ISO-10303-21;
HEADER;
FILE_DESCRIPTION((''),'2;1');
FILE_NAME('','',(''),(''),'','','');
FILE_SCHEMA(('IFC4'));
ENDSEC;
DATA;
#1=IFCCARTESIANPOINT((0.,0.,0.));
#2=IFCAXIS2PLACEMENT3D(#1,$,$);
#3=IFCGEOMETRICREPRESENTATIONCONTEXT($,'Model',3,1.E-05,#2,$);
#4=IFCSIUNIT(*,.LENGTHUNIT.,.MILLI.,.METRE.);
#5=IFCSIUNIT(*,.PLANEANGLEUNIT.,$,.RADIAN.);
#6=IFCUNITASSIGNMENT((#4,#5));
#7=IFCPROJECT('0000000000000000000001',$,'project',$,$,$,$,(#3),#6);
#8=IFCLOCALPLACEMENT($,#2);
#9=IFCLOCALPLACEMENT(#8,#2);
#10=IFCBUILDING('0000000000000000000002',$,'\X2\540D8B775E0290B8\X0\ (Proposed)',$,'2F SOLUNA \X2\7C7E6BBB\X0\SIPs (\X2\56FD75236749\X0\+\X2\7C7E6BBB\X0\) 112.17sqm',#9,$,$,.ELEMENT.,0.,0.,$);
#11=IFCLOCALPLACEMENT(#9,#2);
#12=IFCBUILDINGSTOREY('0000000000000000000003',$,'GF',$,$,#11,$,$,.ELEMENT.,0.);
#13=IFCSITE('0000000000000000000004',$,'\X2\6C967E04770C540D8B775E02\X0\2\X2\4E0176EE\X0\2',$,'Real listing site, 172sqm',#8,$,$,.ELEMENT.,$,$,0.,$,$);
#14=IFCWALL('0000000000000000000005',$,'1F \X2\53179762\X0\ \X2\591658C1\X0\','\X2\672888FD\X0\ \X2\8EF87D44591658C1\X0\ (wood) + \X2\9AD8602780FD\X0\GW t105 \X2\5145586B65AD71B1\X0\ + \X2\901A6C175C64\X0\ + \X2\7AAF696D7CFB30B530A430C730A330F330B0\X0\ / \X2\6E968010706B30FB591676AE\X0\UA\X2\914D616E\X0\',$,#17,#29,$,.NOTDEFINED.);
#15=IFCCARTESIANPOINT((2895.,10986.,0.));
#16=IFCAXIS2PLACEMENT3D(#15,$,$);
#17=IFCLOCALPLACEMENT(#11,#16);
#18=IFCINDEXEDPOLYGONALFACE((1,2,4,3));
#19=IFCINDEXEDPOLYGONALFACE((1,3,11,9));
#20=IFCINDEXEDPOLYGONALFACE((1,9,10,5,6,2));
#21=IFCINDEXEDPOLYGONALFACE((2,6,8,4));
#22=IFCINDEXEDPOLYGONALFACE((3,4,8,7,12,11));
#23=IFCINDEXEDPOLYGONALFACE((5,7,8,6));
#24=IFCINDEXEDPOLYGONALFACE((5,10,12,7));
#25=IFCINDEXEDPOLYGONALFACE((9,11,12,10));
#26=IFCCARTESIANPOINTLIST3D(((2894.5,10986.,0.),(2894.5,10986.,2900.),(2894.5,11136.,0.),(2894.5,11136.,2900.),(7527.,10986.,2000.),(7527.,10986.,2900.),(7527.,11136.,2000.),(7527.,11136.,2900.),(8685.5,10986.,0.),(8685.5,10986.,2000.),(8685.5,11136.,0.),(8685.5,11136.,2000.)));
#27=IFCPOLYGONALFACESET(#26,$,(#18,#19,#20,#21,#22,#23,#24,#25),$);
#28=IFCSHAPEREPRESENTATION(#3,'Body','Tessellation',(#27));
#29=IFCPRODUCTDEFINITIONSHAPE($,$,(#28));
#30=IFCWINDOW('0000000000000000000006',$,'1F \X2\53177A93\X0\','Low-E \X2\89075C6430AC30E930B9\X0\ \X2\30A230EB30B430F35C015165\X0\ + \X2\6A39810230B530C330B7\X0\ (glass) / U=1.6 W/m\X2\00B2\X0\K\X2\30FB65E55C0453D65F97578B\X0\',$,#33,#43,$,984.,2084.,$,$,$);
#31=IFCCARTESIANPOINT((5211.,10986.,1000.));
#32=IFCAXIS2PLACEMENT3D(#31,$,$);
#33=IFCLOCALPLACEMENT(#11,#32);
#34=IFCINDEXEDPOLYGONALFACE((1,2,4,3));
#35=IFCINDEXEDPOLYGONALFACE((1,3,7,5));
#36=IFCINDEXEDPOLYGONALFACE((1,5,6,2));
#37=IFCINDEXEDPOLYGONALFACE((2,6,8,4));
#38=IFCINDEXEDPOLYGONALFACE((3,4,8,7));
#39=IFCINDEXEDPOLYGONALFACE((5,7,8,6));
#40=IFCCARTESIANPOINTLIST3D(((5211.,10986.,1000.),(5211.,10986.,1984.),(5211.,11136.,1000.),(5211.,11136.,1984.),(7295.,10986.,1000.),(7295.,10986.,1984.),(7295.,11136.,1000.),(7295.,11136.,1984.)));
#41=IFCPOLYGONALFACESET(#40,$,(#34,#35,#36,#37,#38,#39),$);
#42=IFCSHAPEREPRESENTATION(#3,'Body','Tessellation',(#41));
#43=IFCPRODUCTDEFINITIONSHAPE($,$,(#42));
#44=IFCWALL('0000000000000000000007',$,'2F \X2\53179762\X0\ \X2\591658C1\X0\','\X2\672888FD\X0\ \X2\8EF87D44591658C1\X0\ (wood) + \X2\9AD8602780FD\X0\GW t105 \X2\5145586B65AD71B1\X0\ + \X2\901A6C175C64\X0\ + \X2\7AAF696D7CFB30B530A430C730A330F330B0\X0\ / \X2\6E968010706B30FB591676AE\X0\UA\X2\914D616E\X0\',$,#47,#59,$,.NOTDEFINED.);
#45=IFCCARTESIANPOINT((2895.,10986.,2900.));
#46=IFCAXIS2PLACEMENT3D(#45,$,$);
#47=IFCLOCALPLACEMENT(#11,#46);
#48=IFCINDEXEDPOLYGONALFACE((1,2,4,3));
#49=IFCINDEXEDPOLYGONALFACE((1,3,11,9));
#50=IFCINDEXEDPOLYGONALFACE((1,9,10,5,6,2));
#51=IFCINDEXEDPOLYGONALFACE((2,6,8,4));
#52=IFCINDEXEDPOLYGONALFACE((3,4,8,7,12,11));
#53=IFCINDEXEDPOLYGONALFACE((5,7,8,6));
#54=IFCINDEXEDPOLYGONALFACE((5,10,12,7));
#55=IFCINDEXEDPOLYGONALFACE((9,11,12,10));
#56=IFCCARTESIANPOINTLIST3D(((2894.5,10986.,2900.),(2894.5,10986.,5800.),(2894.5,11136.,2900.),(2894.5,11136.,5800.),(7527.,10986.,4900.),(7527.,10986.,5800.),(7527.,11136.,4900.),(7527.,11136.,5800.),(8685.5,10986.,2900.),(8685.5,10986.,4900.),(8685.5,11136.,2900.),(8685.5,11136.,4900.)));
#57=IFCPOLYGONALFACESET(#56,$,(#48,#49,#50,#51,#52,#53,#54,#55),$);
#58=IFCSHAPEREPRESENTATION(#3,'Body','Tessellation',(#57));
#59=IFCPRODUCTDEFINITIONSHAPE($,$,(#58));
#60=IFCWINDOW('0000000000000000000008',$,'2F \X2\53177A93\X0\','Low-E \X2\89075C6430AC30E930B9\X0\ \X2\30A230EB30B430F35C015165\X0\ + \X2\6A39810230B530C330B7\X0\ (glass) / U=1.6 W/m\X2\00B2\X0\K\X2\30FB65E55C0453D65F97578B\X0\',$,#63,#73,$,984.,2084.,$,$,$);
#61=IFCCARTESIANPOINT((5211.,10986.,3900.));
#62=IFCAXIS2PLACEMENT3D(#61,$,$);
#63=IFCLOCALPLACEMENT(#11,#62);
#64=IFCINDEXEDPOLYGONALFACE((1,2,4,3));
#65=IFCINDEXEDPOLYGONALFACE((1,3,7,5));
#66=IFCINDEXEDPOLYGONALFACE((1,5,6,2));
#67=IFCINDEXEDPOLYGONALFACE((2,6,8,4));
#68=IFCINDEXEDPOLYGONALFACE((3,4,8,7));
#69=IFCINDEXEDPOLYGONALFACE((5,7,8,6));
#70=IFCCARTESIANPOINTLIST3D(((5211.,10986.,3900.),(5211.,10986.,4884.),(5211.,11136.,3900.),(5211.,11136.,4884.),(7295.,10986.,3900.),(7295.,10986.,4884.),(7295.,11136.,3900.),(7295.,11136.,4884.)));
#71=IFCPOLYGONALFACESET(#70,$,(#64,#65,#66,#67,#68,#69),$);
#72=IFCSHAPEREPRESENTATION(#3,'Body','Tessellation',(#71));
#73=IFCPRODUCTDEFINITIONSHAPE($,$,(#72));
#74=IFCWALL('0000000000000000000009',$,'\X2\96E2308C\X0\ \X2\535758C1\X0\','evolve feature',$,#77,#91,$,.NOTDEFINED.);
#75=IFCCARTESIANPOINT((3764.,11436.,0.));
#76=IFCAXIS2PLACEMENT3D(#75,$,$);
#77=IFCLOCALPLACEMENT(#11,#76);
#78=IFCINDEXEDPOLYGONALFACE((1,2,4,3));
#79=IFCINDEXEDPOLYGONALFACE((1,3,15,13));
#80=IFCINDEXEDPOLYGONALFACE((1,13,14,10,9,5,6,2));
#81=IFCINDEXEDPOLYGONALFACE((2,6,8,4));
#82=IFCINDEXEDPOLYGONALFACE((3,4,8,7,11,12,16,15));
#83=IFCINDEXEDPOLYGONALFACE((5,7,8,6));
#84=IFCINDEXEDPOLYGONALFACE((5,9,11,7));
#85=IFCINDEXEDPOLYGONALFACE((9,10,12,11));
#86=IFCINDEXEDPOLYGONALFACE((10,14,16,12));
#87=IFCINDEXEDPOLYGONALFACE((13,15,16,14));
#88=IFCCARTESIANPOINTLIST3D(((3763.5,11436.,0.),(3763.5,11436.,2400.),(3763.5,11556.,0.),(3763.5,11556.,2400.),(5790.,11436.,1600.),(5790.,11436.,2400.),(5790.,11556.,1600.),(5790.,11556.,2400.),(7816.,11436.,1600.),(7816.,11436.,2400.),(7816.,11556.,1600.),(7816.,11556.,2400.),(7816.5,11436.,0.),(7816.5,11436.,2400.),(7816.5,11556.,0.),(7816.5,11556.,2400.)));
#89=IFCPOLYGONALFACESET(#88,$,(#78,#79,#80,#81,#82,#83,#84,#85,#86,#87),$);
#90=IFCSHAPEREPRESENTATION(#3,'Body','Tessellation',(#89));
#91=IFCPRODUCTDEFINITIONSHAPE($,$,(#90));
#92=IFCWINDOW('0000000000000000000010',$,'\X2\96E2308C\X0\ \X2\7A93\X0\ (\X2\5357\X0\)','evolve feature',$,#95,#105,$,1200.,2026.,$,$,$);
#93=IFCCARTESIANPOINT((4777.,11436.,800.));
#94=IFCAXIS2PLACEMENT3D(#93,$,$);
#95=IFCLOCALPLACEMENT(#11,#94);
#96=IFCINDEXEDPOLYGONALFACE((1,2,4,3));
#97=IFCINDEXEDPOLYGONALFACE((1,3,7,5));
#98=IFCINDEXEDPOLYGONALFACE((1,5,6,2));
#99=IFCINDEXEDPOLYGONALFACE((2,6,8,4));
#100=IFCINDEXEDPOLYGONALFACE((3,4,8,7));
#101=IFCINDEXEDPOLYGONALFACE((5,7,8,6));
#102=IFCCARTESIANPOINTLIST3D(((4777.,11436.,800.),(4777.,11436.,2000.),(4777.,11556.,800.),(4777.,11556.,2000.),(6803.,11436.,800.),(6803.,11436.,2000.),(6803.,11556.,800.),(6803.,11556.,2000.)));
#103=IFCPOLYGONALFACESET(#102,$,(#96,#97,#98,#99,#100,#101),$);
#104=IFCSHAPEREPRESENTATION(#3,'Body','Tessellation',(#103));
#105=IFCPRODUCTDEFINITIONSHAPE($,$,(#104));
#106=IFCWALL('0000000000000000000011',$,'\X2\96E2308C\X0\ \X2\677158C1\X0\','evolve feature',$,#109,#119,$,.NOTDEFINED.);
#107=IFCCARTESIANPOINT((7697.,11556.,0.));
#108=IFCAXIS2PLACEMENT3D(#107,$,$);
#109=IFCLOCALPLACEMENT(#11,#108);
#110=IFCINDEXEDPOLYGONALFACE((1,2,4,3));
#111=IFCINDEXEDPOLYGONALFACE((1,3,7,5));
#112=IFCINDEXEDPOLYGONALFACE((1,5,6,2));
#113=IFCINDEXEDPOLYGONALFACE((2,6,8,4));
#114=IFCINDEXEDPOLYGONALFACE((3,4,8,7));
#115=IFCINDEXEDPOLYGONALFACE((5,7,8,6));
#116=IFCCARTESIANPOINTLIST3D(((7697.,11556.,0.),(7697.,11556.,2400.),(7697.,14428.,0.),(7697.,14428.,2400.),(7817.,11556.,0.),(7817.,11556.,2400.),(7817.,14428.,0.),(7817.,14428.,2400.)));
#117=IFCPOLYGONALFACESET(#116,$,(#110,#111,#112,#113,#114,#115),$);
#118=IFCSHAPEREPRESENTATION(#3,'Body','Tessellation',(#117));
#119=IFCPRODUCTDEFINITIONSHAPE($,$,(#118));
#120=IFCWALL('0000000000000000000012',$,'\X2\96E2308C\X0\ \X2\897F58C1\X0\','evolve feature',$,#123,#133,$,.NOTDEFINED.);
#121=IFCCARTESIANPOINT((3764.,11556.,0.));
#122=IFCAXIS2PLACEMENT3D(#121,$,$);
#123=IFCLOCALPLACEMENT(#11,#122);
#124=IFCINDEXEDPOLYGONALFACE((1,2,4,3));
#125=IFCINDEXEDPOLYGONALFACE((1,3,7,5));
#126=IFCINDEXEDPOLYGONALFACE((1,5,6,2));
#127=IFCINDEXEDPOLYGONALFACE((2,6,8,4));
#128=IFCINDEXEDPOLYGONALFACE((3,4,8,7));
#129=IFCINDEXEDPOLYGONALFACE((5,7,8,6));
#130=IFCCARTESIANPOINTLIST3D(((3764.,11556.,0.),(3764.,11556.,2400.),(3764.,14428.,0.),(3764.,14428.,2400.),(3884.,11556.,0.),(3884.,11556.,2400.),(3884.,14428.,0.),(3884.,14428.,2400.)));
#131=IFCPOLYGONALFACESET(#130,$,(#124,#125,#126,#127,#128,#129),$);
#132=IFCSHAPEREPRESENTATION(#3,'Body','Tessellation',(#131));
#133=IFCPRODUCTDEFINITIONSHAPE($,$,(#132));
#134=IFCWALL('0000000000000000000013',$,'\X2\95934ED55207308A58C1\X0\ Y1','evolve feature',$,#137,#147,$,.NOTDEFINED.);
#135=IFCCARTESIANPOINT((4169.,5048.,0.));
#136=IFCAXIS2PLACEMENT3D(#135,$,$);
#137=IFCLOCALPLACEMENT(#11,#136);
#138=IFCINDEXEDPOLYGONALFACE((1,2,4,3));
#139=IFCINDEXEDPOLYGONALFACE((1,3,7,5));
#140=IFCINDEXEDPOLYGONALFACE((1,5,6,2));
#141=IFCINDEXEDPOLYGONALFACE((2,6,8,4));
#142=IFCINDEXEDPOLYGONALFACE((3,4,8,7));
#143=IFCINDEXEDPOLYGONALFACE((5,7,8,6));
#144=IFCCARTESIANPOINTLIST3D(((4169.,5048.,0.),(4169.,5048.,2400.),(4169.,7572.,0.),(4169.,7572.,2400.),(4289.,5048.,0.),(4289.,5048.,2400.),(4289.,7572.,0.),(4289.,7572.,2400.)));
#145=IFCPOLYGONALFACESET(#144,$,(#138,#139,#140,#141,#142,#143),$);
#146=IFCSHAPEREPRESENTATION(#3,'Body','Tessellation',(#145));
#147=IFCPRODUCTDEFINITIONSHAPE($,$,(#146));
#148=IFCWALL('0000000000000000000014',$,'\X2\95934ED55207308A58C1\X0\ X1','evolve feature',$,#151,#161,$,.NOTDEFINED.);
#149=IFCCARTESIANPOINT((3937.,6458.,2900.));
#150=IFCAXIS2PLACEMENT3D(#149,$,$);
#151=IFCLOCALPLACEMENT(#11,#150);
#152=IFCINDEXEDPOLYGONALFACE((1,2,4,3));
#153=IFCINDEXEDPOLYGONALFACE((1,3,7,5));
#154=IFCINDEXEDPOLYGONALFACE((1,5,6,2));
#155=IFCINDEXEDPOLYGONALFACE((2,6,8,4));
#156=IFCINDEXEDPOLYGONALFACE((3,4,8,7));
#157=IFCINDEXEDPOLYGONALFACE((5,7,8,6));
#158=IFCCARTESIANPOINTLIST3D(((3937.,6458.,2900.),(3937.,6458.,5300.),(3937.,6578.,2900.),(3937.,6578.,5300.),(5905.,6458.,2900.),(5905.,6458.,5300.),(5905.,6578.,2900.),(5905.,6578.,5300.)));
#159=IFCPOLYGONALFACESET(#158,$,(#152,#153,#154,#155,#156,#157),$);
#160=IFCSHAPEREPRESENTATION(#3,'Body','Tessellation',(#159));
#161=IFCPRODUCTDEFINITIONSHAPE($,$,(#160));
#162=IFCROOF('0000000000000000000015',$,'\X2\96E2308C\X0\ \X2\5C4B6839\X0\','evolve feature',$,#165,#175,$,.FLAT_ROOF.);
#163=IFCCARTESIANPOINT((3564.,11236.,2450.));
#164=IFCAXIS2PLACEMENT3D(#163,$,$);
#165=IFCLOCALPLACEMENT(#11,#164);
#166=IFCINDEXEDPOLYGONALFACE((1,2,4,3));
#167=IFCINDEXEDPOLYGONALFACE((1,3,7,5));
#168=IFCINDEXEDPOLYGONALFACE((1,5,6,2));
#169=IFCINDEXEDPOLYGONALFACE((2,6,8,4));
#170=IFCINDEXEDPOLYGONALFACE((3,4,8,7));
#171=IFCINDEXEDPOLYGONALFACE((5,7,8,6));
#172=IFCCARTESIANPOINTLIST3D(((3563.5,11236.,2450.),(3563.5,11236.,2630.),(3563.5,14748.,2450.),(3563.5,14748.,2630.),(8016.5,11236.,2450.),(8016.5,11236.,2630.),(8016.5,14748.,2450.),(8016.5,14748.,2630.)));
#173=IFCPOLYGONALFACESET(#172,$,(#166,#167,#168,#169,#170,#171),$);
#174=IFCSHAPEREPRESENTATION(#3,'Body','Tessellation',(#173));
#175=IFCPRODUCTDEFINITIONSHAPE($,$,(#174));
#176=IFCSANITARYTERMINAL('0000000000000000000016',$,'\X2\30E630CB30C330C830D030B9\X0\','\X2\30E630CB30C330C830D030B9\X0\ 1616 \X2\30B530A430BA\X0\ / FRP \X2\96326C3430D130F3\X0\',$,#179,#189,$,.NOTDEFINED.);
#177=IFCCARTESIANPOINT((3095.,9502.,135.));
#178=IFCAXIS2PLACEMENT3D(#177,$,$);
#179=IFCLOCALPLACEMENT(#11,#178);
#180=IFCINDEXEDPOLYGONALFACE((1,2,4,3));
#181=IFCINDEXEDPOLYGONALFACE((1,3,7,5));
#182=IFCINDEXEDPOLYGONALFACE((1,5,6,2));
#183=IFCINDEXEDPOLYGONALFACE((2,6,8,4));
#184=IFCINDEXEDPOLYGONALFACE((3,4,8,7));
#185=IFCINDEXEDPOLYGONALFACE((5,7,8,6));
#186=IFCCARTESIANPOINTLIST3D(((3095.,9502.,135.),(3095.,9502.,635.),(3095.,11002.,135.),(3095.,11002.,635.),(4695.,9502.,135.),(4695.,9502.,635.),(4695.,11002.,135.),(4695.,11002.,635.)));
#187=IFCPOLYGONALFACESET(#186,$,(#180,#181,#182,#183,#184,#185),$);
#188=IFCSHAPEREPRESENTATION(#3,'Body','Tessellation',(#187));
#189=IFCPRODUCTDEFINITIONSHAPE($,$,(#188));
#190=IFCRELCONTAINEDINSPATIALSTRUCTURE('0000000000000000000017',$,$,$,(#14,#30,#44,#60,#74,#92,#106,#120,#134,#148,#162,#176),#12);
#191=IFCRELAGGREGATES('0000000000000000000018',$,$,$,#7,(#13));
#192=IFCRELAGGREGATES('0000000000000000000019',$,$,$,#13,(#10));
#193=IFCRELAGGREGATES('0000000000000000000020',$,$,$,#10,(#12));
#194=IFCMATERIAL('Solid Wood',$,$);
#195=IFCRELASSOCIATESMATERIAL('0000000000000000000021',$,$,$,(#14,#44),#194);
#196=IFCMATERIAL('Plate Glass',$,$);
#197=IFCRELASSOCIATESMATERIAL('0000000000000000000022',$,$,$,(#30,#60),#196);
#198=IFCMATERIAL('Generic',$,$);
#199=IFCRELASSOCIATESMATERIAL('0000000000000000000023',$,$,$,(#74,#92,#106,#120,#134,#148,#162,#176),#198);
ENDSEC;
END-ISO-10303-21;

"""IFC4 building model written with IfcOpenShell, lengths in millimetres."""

from ifc_helpers import new_model, si_unit, frame, frame_2d, origin, place, context, project, spatial, rectangle, extrude, material, element, fill, save


model = new_model("IFC4")

# Units and contexts
model_context = context("Model", 3, precision=1e-05, world=origin())
ifc_project = project(units=[si_unit("LENGTHUNIT", "METRE", prefix="MILLI"), si_unit("PLANEANGLEUNIT", "RADIAN")], contexts=[model_context])

# Site, building, storey
site_placement = place(None, origin())
site = spatial("IfcSite", under=ifc_project, at=site_placement, Name="沖縄県名護市2丁目2", ObjectType="Real listing site, 172sqm", CompositionType="ELEMENT", RefElevation=0.0)
building_placement = place(site_placement, origin())
building = spatial("IfcBuilding", under=site, at=building_placement, Name="名護市邸 (Proposed)", ObjectType="2F SOLUNA 籾殻SIPs (国産杉+籾殻) 112.17sqm", CompositionType="ELEMENT", ElevationOfRefHeight=0.0, ElevationOfTerrain=0.0)
storey_placement = place(building_placement, origin())
storey = spatial("IfcBuildingStorey", under=building, at=storey_placement, Name="GF", CompositionType="ELEMENT", Elevation=0.0)

# Shared definitions
ifc_material_1 = material(Name="Generic")

# Wall, opening, window
ifc_material_2 = material(Name="Solid Wood")
wall_1_placement = place(storey_placement, frame((2895.0, 10986.0, 0.0)))
wall_1 = element("IfcWall", 1, at=wall_1_placement, inside=storey, material=ifc_material_2, Name="1F 北面 外壁", Description="木製 軸組外壁 (wood) + 高性能GW t105 充填断熱 + 通気層 + 窯業系サイディング / 準耐火・外皮UA配慮", PredefinedType="NOTDEFINED", context=model_context, shape_type="SweptSolid", body=[
    extrude(rectangle(XDim=5791.0, YDim=150.0, at=frame_2d((2895.0, 75.0))), frame((2895.0, 10986.0, 0.0)), (0.0, 0.0, 1.0), 2900.0),
])
opening_1_placement = place(storey_placement, frame((5211.0, 10986.0, 1000.0)))
opening_1 = element("IfcOpeningElement", 2, at=opening_1_placement, cuts=wall_1, PredefinedType="NOTDEFINED", context=model_context, shape_type="SweptSolid", body=[
    extrude(rectangle(XDim=2084.0, YDim=150.0, at=frame_2d((1042.0, 75.0))), frame((5211.0, 10986.0, 1000.0)), (0.0, 0.0, 1.0), 984.0),
])
ifc_material_3 = material(Name="Plate Glass")
window_1_placement = place(storey_placement, frame((5211.0, 10986.0, 1000.0)))
window_1 = element("IfcWindow", 3, at=window_1_placement, inside=storey, material=ifc_material_3, Name="1F 北窓", Description="Low-E 複層ガラス アルゴン封入 + 樹脂サッシ (glass) / U=1.6 W/m²K・日射取得型", OverallHeight=984.0, OverallWidth=2084.0, context=model_context, shape_type="SweptSolid", body=[
    extrude(rectangle(XDim=2084.0, YDim=150.0, at=frame_2d((1042.0, 75.0))), frame((5211.0, 10986.0, 1000.0)), (0.0, 0.0, 1.0), 984.0),
])
fill(opening_1, window_1)

# Wall, opening, window
wall_2_placement = place(storey_placement, frame((2895.0, 10986.0, 2900.0)))
wall_2 = element("IfcWall", 4, at=wall_2_placement, inside=storey, material=ifc_material_2, Name="2F 北面 外壁", Description="木製 軸組外壁 (wood) + 高性能GW t105 充填断熱 + 通気層 + 窯業系サイディング / 準耐火・外皮UA配慮", PredefinedType="NOTDEFINED", context=model_context, shape_type="SweptSolid", body=[
    extrude(rectangle(XDim=5791.0, YDim=150.0, at=frame_2d((2895.0, 75.0))), frame((2895.0, 10986.0, 2900.0)), (0.0, 0.0, 1.0), 2900.0),
])
opening_2_placement = place(storey_placement, frame((5211.0, 10986.0, 3900.0)))
opening_2 = element("IfcOpeningElement", 5, at=opening_2_placement, cuts=wall_2, PredefinedType="NOTDEFINED", context=model_context, shape_type="SweptSolid", body=[
    extrude(rectangle(XDim=2084.0, YDim=150.0, at=frame_2d((1042.0, 75.0))), frame((5211.0, 10986.0, 3900.0)), (0.0, 0.0, 1.0), 984.0),
])
window_2_placement = place(storey_placement, frame((5211.0, 10986.0, 3900.0)))
window_2 = element("IfcWindow", 6, at=window_2_placement, inside=storey, material=ifc_material_3, Name="2F 北窓", Description="Low-E 複層ガラス アルゴン封入 + 樹脂サッシ (glass) / U=1.6 W/m²K・日射取得型", OverallHeight=984.0, OverallWidth=2084.0, context=model_context, shape_type="SweptSolid", body=[
    extrude(rectangle(XDim=2084.0, YDim=150.0, at=frame_2d((1042.0, 75.0))), frame((5211.0, 10986.0, 3900.0)), (0.0, 0.0, 1.0), 984.0),
])
fill(opening_2, window_2)

# Wall, opening, window
wall_3_placement = place(storey_placement, frame((3764.0, 11436.0, 0.0)))
wall_3 = element("IfcWall", 7, at=wall_3_placement, inside=storey, material=ifc_material_1, Name="離れ 南壁", Description="evolve feature", PredefinedType="NOTDEFINED", context=model_context, shape_type="SweptSolid", body=[
    extrude(rectangle(XDim=4053.0, YDim=120.0, at=frame_2d((2026.0, 60.0))), frame((3764.0, 11436.0, 0.0)), (0.0, 0.0, 1.0), 2400.0),
])
opening_3_placement = place(storey_placement, frame((4777.0, 11436.0, 800.0)))
opening_3 = element("IfcOpeningElement", 8, at=opening_3_placement, cuts=wall_3, PredefinedType="NOTDEFINED", context=model_context, shape_type="SweptSolid", body=[
    extrude(rectangle(XDim=2026.0, YDim=120.0, at=frame_2d((1013.0, 60.0))), frame((4777.0, 11436.0, 800.0)), (0.0, 0.0, 1.0), 1200.0),
])
window_3_placement = place(storey_placement, frame((4777.0, 11436.0, 800.0)))
window_3 = element("IfcWindow", 9, at=window_3_placement, inside=storey, material=ifc_material_1, Name="離れ 窓 (南)", Description="evolve feature", OverallHeight=1200.0, OverallWidth=2026.0, context=model_context, shape_type="SweptSolid", body=[
    extrude(rectangle(XDim=2026.0, YDim=120.0, at=frame_2d((1013.0, 60.0))), frame((4777.0, 11436.0, 800.0)), (0.0, 0.0, 1.0), 1200.0),
])
fill(opening_3, window_3)

# Walls
wall_4_placement = place(storey_placement, frame((7697.0, 11556.0, 0.0)))
element("IfcWall", 10, at=wall_4_placement, inside=storey, material=ifc_material_1, Name="離れ 東壁", Description="evolve feature", PredefinedType="NOTDEFINED", context=model_context, shape_type="SweptSolid", body=[
    extrude(rectangle(XDim=120.0, YDim=2872.0, at=frame_2d((60.0, 1436.0))), frame((7697.0, 11556.0, 0.0)), (0.0, 0.0, 1.0), 2400.0),
])
wall_5_placement = place(storey_placement, frame((3764.0, 11556.0, 0.0)))
element("IfcWall", 11, at=wall_5_placement, inside=storey, material=ifc_material_1, Name="離れ 西壁", Description="evolve feature", PredefinedType="NOTDEFINED", context=model_context, shape_type="SweptSolid", body=[
    extrude(rectangle(XDim=120.0, YDim=2872.0, at=frame_2d((60.0, 1436.0))), frame((3764.0, 11556.0, 0.0)), (0.0, 0.0, 1.0), 2400.0),
])
wall_6_placement = place(storey_placement, frame((4169.0, 5048.0, 0.0)))
element("IfcWall", 12, at=wall_6_placement, inside=storey, material=ifc_material_1, Name="間仕切り壁 Y1", Description="evolve feature", PredefinedType="NOTDEFINED", context=model_context, shape_type="SweptSolid", body=[
    extrude(rectangle(XDim=120.0, YDim=2524.0, at=frame_2d((60.0, 1262.0))), frame((4169.0, 5048.0, 0.0)), (0.0, 0.0, 1.0), 2400.0),
])
wall_7_placement = place(storey_placement, frame((3937.0, 6458.0, 2900.0)))
element("IfcWall", 13, at=wall_7_placement, inside=storey, material=ifc_material_1, Name="間仕切り壁 X1", Description="evolve feature", PredefinedType="NOTDEFINED", context=model_context, shape_type="SweptSolid", body=[
    extrude(rectangle(XDim=1968.0, YDim=120.0, at=frame_2d((984.0, 60.0))), frame((3937.0, 6458.0, 2900.0)), (0.0, 0.0, 1.0), 2400.0),
])

# Roof
roof_placement = place(storey_placement, frame((3564.0, 11236.0, 2450.0)))
element("IfcRoof", 14, at=roof_placement, inside=storey, material=ifc_material_1, Name="離れ 屋根", Description="evolve feature", PredefinedType="FLAT_ROOF", context=model_context, shape_type="SweptSolid", body=[
    extrude(rectangle(XDim=4453.0, YDim=3512.0, at=frame_2d((2226.0, 1756.0))), frame((3564.0, 11236.0, 2450.0)), (0.0, 0.0, 1.0), 180.0),
])

# Sanitary terminal
sanitary_terminal_1_placement = place(storey_placement, frame((3095.0, 9502.0, 135.0)))
element("IfcSanitaryTerminal", 15, at=sanitary_terminal_1_placement, inside=storey, material=ifc_material_1, Name="ユニットバス", Description="ユニットバス 1616 サイズ / FRP 防水パン", PredefinedType="NOTDEFINED", context=model_context, shape_type="SweptSolid", body=[
    extrude(rectangle(XDim=1600.0, YDim=1500.0, at=frame_2d((800.0, 750.0))), frame((3095.0, 9502.0, 135.0)), (0.0, 0.0, 1.0), 500.0),
])

save(model, "model.ifc")
